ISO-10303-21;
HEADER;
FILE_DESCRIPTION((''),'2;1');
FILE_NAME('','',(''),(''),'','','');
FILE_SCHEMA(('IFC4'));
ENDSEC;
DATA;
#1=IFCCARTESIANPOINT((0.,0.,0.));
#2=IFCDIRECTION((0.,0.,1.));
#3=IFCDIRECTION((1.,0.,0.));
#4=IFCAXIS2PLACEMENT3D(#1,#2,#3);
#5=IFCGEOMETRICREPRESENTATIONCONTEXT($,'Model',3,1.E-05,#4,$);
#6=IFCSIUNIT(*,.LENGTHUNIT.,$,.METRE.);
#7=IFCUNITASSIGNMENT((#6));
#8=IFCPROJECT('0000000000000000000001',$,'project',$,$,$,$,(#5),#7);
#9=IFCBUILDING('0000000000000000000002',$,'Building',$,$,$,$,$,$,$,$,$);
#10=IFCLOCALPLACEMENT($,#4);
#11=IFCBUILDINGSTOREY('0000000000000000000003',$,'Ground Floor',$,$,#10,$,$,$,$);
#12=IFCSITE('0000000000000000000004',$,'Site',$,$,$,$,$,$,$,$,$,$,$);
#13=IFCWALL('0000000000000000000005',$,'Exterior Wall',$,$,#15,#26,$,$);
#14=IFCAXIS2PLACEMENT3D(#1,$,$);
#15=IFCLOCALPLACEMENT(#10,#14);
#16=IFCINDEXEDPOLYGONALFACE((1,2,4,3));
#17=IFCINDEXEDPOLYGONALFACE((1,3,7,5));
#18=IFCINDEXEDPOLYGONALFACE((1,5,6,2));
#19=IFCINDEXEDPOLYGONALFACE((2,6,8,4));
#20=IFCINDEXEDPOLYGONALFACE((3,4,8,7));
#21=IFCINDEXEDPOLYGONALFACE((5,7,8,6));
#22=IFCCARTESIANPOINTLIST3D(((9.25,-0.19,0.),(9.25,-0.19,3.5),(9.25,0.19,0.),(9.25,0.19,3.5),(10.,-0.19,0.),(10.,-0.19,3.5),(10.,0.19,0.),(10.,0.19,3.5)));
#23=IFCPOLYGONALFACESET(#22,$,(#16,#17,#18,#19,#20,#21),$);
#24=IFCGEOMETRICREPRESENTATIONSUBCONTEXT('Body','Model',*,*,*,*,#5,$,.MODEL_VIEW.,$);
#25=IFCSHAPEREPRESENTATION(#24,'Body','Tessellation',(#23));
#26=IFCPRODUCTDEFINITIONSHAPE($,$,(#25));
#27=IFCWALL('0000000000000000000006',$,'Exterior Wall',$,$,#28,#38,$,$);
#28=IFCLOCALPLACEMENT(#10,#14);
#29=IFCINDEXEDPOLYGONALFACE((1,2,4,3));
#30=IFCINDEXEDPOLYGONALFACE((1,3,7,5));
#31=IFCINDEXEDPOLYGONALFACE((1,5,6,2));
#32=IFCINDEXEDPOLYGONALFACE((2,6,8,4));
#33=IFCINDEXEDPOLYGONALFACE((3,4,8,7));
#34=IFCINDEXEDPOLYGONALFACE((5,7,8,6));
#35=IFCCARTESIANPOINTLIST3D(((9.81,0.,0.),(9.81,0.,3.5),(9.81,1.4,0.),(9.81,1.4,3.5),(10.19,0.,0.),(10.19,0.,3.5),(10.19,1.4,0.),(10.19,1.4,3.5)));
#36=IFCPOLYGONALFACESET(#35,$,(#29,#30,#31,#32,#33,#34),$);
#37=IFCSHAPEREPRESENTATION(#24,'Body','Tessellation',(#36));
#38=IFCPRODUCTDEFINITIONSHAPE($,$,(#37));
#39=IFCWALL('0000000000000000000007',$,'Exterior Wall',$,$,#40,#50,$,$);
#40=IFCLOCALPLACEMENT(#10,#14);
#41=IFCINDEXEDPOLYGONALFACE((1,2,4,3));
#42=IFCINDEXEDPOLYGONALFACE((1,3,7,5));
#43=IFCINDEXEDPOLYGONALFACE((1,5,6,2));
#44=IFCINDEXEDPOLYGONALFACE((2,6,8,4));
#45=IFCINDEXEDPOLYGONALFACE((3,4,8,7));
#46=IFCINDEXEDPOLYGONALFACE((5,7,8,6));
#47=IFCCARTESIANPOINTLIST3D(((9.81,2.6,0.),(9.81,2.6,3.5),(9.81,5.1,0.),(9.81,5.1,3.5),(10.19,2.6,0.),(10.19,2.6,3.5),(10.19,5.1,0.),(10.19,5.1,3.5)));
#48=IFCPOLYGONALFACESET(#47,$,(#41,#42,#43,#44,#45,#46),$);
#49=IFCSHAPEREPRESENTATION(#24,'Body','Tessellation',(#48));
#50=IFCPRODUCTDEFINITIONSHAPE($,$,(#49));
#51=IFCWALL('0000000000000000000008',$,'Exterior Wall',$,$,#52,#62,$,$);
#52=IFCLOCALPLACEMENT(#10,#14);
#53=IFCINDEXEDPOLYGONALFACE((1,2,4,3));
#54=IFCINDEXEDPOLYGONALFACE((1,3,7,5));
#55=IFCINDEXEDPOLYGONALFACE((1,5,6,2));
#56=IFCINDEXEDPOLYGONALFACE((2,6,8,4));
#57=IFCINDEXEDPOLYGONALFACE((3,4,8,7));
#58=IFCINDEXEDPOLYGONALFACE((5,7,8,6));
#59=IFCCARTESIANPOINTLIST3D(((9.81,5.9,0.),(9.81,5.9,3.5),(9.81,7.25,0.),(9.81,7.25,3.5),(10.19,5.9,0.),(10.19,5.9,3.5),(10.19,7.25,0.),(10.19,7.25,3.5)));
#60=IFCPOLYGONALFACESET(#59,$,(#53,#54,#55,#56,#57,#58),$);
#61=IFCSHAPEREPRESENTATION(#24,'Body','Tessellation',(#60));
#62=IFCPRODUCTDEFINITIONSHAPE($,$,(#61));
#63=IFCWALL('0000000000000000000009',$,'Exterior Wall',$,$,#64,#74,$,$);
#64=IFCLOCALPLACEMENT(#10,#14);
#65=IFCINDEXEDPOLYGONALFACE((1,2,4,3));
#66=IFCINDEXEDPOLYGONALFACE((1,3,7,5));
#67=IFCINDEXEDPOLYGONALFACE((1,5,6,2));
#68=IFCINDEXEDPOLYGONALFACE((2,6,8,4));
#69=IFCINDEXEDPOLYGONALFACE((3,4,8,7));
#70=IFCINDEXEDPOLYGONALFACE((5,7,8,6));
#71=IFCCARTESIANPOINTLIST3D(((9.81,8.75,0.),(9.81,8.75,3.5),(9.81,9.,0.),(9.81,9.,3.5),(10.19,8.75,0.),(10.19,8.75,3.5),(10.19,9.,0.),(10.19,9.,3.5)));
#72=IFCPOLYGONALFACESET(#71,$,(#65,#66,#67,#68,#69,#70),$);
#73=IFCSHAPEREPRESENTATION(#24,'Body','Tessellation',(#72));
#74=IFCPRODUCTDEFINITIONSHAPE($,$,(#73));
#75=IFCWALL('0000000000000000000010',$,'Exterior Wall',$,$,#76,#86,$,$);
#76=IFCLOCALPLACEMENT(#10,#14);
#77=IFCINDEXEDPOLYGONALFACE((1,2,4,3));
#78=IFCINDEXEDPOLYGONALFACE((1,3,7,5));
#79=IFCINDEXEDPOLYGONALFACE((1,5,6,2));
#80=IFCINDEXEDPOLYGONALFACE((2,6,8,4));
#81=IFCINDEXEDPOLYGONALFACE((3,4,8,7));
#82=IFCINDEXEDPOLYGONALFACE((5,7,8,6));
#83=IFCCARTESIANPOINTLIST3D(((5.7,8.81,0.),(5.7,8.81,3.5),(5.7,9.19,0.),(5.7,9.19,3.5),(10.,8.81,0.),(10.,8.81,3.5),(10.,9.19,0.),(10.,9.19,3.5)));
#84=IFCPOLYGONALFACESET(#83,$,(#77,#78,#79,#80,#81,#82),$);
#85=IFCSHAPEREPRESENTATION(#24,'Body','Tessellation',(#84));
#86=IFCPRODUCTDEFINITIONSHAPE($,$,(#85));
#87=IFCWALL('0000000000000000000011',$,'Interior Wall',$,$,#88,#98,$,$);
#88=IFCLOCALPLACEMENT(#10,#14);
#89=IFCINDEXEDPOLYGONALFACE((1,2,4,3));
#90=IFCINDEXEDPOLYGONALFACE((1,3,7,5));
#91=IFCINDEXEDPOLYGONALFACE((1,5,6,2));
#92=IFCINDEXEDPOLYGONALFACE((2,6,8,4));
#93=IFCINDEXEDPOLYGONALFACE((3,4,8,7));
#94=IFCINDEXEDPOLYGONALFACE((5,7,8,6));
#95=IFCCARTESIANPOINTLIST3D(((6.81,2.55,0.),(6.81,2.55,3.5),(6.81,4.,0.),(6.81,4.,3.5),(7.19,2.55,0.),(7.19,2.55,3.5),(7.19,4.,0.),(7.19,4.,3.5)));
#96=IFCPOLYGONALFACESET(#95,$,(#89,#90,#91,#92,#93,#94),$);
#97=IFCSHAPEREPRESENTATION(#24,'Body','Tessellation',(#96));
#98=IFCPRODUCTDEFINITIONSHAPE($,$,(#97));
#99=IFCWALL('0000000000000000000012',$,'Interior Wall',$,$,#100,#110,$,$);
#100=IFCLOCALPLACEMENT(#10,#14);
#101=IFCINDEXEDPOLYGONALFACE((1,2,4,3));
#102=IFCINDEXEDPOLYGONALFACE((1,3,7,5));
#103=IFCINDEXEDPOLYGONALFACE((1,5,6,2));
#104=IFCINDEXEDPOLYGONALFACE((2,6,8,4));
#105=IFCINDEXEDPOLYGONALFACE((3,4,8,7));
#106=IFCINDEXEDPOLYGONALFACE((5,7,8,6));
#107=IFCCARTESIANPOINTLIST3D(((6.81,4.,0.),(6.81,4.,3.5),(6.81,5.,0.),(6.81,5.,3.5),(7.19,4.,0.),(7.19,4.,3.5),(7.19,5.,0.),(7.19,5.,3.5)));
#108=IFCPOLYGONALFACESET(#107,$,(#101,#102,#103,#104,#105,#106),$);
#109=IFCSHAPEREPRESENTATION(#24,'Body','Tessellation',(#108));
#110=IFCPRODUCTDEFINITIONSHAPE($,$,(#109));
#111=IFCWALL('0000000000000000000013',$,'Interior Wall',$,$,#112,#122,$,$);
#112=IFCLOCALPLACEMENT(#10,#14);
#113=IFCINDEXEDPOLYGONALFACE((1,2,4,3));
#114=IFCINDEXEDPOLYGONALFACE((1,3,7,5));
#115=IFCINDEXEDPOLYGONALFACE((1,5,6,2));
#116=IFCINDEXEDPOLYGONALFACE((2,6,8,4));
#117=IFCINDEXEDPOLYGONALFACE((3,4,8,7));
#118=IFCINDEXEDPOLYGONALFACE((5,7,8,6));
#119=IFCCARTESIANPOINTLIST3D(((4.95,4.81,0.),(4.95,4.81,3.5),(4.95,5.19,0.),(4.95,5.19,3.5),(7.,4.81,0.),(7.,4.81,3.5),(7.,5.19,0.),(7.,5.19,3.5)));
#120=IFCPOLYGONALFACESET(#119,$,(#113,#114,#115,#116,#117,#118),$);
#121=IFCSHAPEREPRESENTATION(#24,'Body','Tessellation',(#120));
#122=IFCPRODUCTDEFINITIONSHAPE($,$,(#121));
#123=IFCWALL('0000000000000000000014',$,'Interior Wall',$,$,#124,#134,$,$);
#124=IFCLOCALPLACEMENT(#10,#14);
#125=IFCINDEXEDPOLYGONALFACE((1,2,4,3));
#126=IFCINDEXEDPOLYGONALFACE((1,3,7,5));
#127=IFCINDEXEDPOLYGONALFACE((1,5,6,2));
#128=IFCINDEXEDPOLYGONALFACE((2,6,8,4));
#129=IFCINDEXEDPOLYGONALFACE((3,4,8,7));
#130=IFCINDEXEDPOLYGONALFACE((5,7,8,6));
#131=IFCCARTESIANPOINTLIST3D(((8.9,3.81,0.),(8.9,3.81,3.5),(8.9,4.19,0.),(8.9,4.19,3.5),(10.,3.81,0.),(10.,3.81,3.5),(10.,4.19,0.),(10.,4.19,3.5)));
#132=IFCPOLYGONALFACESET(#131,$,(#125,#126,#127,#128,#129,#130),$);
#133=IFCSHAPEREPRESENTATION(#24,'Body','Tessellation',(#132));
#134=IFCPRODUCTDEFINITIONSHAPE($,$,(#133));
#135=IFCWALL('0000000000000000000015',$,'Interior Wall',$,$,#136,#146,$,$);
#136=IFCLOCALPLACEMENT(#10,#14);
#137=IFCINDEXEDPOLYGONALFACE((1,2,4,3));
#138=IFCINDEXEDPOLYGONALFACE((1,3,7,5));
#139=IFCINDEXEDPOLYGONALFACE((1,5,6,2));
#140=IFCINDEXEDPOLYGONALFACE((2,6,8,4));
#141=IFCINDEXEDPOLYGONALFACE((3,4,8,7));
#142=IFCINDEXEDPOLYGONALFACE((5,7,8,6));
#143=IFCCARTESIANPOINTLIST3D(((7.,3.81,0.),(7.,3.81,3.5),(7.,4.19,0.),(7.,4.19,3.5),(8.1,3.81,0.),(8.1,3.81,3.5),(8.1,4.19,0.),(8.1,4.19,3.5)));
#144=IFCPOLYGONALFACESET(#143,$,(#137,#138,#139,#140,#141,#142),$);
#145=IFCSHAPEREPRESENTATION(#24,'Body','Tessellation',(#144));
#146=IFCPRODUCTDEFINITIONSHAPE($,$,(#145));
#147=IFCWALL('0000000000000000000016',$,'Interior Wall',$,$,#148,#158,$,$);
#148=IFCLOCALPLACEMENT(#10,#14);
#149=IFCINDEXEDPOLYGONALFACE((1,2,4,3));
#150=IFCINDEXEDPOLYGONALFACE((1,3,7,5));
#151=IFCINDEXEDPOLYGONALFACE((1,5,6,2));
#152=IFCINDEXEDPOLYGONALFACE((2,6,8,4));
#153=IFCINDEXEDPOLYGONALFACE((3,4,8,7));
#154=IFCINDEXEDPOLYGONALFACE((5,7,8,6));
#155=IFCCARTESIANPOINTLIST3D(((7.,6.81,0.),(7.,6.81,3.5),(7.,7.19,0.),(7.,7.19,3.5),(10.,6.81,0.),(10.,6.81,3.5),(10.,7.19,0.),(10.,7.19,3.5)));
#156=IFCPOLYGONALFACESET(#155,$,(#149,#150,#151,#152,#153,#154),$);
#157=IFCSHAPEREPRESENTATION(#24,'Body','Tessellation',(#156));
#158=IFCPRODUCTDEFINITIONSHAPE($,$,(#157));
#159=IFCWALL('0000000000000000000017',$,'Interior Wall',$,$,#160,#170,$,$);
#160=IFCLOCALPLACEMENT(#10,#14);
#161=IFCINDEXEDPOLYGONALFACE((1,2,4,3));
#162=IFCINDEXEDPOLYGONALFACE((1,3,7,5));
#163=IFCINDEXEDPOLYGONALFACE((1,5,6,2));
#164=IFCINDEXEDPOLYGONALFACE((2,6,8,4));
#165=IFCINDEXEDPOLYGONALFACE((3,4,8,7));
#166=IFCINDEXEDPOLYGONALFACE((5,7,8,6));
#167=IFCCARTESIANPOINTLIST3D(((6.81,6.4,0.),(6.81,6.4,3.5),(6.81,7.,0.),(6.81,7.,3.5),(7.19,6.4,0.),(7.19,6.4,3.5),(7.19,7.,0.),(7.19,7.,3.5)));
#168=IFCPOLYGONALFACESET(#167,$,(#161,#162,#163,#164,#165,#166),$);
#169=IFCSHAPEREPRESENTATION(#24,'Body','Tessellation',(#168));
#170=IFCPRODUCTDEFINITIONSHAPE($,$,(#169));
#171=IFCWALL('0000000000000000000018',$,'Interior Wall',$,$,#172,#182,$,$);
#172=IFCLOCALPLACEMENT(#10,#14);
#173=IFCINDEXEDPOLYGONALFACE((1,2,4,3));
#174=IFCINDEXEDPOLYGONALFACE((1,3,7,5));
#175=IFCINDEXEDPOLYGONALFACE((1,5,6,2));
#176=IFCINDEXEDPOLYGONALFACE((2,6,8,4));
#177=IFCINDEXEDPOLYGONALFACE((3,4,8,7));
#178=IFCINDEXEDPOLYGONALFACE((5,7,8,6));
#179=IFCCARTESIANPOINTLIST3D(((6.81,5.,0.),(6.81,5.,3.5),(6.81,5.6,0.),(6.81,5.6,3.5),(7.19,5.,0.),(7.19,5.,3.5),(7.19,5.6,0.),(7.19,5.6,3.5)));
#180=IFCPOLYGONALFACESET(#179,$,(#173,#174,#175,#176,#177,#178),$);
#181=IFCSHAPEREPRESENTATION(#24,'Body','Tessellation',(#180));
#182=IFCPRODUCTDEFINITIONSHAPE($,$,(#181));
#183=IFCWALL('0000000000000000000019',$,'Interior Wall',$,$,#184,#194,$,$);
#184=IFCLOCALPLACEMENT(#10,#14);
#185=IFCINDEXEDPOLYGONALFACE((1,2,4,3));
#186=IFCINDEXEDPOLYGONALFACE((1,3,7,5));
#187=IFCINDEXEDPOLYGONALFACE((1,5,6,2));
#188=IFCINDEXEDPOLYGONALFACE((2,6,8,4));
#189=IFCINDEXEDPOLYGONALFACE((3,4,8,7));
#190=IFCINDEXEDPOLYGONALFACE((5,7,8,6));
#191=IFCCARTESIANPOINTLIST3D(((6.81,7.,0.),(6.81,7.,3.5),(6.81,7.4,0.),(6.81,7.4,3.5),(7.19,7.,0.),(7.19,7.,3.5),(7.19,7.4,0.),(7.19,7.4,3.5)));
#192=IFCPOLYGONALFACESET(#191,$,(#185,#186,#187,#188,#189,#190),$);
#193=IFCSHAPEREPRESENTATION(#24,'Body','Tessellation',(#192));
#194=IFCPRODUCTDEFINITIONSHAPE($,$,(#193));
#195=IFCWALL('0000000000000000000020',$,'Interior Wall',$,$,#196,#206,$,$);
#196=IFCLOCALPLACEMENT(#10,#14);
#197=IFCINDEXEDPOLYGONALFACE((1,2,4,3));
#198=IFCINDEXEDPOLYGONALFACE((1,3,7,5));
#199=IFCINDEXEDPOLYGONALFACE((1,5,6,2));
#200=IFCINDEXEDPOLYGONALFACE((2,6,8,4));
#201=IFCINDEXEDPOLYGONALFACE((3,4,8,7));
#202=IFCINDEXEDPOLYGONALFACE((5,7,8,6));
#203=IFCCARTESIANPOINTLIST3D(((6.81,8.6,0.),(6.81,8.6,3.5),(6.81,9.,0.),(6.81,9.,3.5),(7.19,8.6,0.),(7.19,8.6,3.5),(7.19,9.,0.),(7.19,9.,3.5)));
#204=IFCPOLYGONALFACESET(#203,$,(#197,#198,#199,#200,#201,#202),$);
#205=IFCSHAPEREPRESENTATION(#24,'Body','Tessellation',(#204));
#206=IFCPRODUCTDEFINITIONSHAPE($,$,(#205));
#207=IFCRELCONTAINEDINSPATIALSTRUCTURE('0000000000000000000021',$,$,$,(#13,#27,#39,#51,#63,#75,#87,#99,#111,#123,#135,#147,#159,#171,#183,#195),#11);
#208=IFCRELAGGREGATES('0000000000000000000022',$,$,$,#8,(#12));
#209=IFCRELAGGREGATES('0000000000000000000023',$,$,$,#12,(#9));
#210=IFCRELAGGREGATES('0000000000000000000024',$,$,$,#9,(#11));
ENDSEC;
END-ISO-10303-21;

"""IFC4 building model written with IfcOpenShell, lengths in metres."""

from ifc_helpers import new_model, si_unit, frame, origin_with_axes, place, context, subcontext, project, spatial, indexed_curve, outline, extrude, element, save


model = new_model("IFC4")

# Units and contexts
model_context = context("Model", 3, precision=1e-05, world=origin_with_axes())
body_context = subcontext(model_context, "Body", "Model", "MODEL_VIEW")
ifc_project = project(units=[si_unit("LENGTHUNIT", "METRE")], contexts=[model_context])

# Site, building, storey
site = spatial("IfcSite", under=ifc_project, Name="Site")
building = spatial("IfcBuilding", under=site, Name="Building")
storey_placement = place(None, origin_with_axes())
storey = spatial("IfcBuildingStorey", under=building, at=storey_placement, Name="Ground Floor")

# Walls
wall_1_placement = place(storey_placement, frame((9.25, 0.0, 0.0), z_axis=(0.0, 0.0, 1.0), x_axis=(1.0, 0.0, 0.0)))
element("IfcWall", 1, at=wall_1_placement, inside=storey, Name="Exterior Wall", context=body_context, shape_type="SweptSolid", body=[
    extrude(outline(indexed_curve([(0.0, 0.0), (0.0, 0.38), (0.75, 0.38), (0.75, 0.0), (0.0, 0.0)], self_intersect=False)), frame((0.0, -0.19, 0.0), z_axis=(0.0, 0.0, 1.0), x_axis=(1.0, 0.0, 0.0)), (0.0, 0.0, 1.0), 3.5),
])
wall_2_placement = place(storey_placement, frame((10.0, 0.0, 0.0), z_axis=(0.0, 0.0, 1.0), x_axis=(0.0, 1.0, 0.0)))
element("IfcWall", 2, at=wall_2_placement, inside=storey, Name="Exterior Wall", context=body_context, shape_type="SweptSolid", body=[
    extrude(outline(indexed_curve([(0.0, 0.0), (0.0, 0.38), (1.4, 0.38), (1.4, 0.0), (0.0, 0.0)], self_intersect=False)), frame((0.0, -0.19, 0.0), z_axis=(0.0, 0.0, 1.0), x_axis=(1.0, 0.0, 0.0)), (0.0, 0.0, 1.0), 3.5),
])
wall_3_placement = place(storey_placement, frame((10.0, 2.6, 0.0), z_axis=(0.0, 0.0, 1.0), x_axis=(0.0, 1.0, 0.0)))
element("IfcWall", 3, at=wall_3_placement, inside=storey, Name="Exterior Wall", context=body_context, shape_type="SweptSolid", body=[
    extrude(outline(indexed_curve([(0.0, 0.0), (0.0, 0.38), (2.5, 0.38), (2.5, 0.0), (0.0, 0.0)], self_intersect=False)), frame((0.0, -0.19, 0.0), z_axis=(0.0, 0.0, 1.0), x_axis=(1.0, 0.0, 0.0)), (0.0, 0.0, 1.0), 3.5),
])
wall_4_placement = place(storey_placement, frame((10.0, 5.9, 0.0), z_axis=(0.0, 0.0, 1.0), x_axis=(0.0, 1.0, 0.0)))
element("IfcWall", 4, at=wall_4_placement, inside=storey, Name="Exterior Wall", context=body_context, shape_type="SweptSolid", body=[
    extrude(outline(indexed_curve([(0.0, 0.0), (0.0, 0.38), (1.35, 0.38), (1.35, 0.0), (0.0, 0.0)], self_intersect=False)), frame((0.0, -0.19, 0.0), z_axis=(0.0, 0.0, 1.0), x_axis=(1.0, 0.0, 0.0)), (0.0, 0.0, 1.0), 3.5),
])
wall_5_placement = place(storey_placement, frame((10.0, 8.75, 0.0), z_axis=(0.0, 0.0, 1.0), x_axis=(0.0, 1.0, 0.0)))
element("IfcWall", 5, at=wall_5_placement, inside=storey, Name="Exterior Wall", context=body_context, shape_type="SweptSolid", body=[
    extrude(outline(indexed_curve([(0.0, 0.0), (0.0, 0.38), (0.25, 0.38), (0.25, 0.0), (0.0, 0.0)], self_intersect=False)), frame((0.0, -0.19, 0.0), z_axis=(0.0, 0.0, 1.0), x_axis=(1.0, 0.0, 0.0)), (0.0, 0.0, 1.0), 3.5),
])
wall_6_placement = place(storey_placement, frame((10.0, 9.0, 0.0), z_axis=(0.0, 0.0, 1.0), x_axis=(-1.0, 0.0, 0.0)))
element("IfcWall", 6, at=wall_6_placement, inside=storey, Name="Exterior Wall", context=body_context, shape_type="SweptSolid", body=[
    extrude(outline(indexed_curve([(0.0, 0.0), (0.0, 0.38), (4.3, 0.38), (4.3, 0.0), (0.0, 0.0)], self_intersect=False)), frame((0.0, -0.19, 0.0), z_axis=(0.0, 0.0, 1.0), x_axis=(1.0, 0.0, 0.0)), (0.0, 0.0, 1.0), 3.5),
])
wall_7_placement = place(storey_placement, frame((7.0, 2.55, 0.0), z_axis=(0.0, 0.0, 1.0), x_axis=(0.0, 1.0, 0.0)))
element("IfcWall", 7, at=wall_7_placement, inside=storey, Name="Interior Wall", context=body_context, shape_type="SweptSolid", body=[
    extrude(outline(indexed_curve([(0.0, 0.0), (0.0, 0.38), (1.45, 0.38), (1.45, 0.0), (0.0, 0.0)], self_intersect=False)), frame((0.0, -0.19, 0.0), z_axis=(0.0, 0.0, 1.0), x_axis=(1.0, 0.0, 0.0)), (0.0, 0.0, 1.0), 3.5),
])
wall_8_placement = place(storey_placement, frame((7.0, 4.0, 0.0), z_axis=(0.0, 0.0, 1.0), x_axis=(0.0, 1.0, 0.0)))
element("IfcWall", 8, at=wall_8_placement, inside=storey, Name="Interior Wall", context=body_context, shape_type="SweptSolid", body=[
    extrude(outline(indexed_curve([(0.0, 0.0), (0.0, 0.38), (1.0, 0.38), (1.0, 0.0), (0.0, 0.0)], self_intersect=False)), frame((0.0, -0.19, 0.0), z_axis=(0.0, 0.0, 1.0), x_axis=(1.0, 0.0, 0.0)), (0.0, 0.0, 1.0), 3.5),
])
wall_9_placement = place(storey_placement, frame((7.0, 5.0, 0.0), z_axis=(0.0, 0.0, 1.0), x_axis=(-1.0, 0.0, 0.0)))
element("IfcWall", 9, at=wall_9_placement, inside=storey, Name="Interior Wall", context=body_context, shape_type="SweptSolid", body=[
    extrude(outline(indexed_curve([(0.0, 0.0), (0.0, 0.38), (2.05, 0.38), (2.05, 0.0), (0.0, 0.0)], self_intersect=False)), frame((0.0, -0.19, 0.0), z_axis=(0.0, 0.0, 1.0), x_axis=(1.0, 0.0, 0.0)), (0.0, 0.0, 1.0), 3.5),
])
for number, where, z_axis, x_axis, name in (
    (10, (10.0, 4.0, 0.0), (0.0, 0.0, 1.0), (-1.0, 0.0, 0.0), "Interior Wall"),
    (11, (8.1, 4.0, 0.0), (0.0, 0.0, 1.0), (-1.0, 0.0, 0.0), "Interior Wall"),
):
    element("IfcWall", number, at=place(storey_placement, frame(where, z_axis=z_axis, x_axis=x_axis)), inside=storey, Name=name, context=body_context, shape_type="SweptSolid", body=[
        extrude(outline(indexed_curve([(0.0, 0.0), (0.0, 0.38), (1.1, 0.38), (1.1, 0.0), (0.0, 0.0)], self_intersect=False)), frame((0.0, -0.19, 0.0), z_axis=(0.0, 0.0, 1.0), x_axis=(1.0, 0.0, 0.0)), (0.0, 0.0, 1.0), 3.5),
    ])
wall_10_placement = place(storey_placement, frame((10.0, 7.0, 0.0), z_axis=(0.0, 0.0, 1.0), x_axis=(-1.0, 0.0, 0.0)))
element("IfcWall", 12, at=wall_10_placement, inside=storey, Name="Interior Wall", context=body_context, shape_type="SweptSolid", body=[
    extrude(outline(indexed_curve([(0.0, 0.0), (0.0, 0.38), (3.0, 0.38), (3.0, 0.0), (0.0, 0.0)], self_intersect=False)), frame((0.0, -0.19, 0.0), z_axis=(0.0, 0.0, 1.0), x_axis=(1.0, 0.0, 0.0)), (0.0, 0.0, 1.0), 3.5),
])
for number, where, z_axis, x_axis, name in (
    (13, (7.0, 7.0, 0.0), (0.0, 0.0, 1.0), (0.0, -1.0, 0.0), "Interior Wall"),
    (14, (7.0, 5.6, 0.0), (0.0, 0.0, 1.0), (0.0, -1.0, 0.0), "Interior Wall"),
):
    element("IfcWall", number, at=place(storey_placement, frame(where, z_axis=z_axis, x_axis=x_axis)), inside=storey, Name=name, context=body_context, shape_type="SweptSolid", body=[
        extrude(outline(indexed_curve([(0.0, 0.0), (0.0, 0.38), (0.6, 0.38), (0.6, 0.0), (0.0, 0.0)], self_intersect=False)), frame((0.0, -0.19, 0.0), z_axis=(0.0, 0.0, 1.0), x_axis=(1.0, 0.0, 0.0)), (0.0, 0.0, 1.0), 3.5),
    ])
for number, where, z_axis, x_axis, name in (
    (15, (7.0, 7.0, 0.0), (0.0, 0.0, 1.0), (0.0, 1.0, 0.0), "Interior Wall"),
    (16, (7.0, 8.6, 0.0), (0.0, 0.0, 1.0), (0.0, 1.0, 0.0), "Interior Wall"),
):
    element("IfcWall", number, at=place(storey_placement, frame(where, z_axis=z_axis, x_axis=x_axis)), inside=storey, Name=name, context=body_context, shape_type="SweptSolid", body=[
        extrude(outline(indexed_curve([(0.0, 0.0), (0.0, 0.38), (0.4, 0.38), (0.4, 0.0), (0.0, 0.0)], self_intersect=False)), frame((0.0, -0.19, 0.0), z_axis=(0.0, 0.0, 1.0), x_axis=(1.0, 0.0, 0.0)), (0.0, 0.0, 1.0), 3.5),
    ])

save(model, "model.ifc")
